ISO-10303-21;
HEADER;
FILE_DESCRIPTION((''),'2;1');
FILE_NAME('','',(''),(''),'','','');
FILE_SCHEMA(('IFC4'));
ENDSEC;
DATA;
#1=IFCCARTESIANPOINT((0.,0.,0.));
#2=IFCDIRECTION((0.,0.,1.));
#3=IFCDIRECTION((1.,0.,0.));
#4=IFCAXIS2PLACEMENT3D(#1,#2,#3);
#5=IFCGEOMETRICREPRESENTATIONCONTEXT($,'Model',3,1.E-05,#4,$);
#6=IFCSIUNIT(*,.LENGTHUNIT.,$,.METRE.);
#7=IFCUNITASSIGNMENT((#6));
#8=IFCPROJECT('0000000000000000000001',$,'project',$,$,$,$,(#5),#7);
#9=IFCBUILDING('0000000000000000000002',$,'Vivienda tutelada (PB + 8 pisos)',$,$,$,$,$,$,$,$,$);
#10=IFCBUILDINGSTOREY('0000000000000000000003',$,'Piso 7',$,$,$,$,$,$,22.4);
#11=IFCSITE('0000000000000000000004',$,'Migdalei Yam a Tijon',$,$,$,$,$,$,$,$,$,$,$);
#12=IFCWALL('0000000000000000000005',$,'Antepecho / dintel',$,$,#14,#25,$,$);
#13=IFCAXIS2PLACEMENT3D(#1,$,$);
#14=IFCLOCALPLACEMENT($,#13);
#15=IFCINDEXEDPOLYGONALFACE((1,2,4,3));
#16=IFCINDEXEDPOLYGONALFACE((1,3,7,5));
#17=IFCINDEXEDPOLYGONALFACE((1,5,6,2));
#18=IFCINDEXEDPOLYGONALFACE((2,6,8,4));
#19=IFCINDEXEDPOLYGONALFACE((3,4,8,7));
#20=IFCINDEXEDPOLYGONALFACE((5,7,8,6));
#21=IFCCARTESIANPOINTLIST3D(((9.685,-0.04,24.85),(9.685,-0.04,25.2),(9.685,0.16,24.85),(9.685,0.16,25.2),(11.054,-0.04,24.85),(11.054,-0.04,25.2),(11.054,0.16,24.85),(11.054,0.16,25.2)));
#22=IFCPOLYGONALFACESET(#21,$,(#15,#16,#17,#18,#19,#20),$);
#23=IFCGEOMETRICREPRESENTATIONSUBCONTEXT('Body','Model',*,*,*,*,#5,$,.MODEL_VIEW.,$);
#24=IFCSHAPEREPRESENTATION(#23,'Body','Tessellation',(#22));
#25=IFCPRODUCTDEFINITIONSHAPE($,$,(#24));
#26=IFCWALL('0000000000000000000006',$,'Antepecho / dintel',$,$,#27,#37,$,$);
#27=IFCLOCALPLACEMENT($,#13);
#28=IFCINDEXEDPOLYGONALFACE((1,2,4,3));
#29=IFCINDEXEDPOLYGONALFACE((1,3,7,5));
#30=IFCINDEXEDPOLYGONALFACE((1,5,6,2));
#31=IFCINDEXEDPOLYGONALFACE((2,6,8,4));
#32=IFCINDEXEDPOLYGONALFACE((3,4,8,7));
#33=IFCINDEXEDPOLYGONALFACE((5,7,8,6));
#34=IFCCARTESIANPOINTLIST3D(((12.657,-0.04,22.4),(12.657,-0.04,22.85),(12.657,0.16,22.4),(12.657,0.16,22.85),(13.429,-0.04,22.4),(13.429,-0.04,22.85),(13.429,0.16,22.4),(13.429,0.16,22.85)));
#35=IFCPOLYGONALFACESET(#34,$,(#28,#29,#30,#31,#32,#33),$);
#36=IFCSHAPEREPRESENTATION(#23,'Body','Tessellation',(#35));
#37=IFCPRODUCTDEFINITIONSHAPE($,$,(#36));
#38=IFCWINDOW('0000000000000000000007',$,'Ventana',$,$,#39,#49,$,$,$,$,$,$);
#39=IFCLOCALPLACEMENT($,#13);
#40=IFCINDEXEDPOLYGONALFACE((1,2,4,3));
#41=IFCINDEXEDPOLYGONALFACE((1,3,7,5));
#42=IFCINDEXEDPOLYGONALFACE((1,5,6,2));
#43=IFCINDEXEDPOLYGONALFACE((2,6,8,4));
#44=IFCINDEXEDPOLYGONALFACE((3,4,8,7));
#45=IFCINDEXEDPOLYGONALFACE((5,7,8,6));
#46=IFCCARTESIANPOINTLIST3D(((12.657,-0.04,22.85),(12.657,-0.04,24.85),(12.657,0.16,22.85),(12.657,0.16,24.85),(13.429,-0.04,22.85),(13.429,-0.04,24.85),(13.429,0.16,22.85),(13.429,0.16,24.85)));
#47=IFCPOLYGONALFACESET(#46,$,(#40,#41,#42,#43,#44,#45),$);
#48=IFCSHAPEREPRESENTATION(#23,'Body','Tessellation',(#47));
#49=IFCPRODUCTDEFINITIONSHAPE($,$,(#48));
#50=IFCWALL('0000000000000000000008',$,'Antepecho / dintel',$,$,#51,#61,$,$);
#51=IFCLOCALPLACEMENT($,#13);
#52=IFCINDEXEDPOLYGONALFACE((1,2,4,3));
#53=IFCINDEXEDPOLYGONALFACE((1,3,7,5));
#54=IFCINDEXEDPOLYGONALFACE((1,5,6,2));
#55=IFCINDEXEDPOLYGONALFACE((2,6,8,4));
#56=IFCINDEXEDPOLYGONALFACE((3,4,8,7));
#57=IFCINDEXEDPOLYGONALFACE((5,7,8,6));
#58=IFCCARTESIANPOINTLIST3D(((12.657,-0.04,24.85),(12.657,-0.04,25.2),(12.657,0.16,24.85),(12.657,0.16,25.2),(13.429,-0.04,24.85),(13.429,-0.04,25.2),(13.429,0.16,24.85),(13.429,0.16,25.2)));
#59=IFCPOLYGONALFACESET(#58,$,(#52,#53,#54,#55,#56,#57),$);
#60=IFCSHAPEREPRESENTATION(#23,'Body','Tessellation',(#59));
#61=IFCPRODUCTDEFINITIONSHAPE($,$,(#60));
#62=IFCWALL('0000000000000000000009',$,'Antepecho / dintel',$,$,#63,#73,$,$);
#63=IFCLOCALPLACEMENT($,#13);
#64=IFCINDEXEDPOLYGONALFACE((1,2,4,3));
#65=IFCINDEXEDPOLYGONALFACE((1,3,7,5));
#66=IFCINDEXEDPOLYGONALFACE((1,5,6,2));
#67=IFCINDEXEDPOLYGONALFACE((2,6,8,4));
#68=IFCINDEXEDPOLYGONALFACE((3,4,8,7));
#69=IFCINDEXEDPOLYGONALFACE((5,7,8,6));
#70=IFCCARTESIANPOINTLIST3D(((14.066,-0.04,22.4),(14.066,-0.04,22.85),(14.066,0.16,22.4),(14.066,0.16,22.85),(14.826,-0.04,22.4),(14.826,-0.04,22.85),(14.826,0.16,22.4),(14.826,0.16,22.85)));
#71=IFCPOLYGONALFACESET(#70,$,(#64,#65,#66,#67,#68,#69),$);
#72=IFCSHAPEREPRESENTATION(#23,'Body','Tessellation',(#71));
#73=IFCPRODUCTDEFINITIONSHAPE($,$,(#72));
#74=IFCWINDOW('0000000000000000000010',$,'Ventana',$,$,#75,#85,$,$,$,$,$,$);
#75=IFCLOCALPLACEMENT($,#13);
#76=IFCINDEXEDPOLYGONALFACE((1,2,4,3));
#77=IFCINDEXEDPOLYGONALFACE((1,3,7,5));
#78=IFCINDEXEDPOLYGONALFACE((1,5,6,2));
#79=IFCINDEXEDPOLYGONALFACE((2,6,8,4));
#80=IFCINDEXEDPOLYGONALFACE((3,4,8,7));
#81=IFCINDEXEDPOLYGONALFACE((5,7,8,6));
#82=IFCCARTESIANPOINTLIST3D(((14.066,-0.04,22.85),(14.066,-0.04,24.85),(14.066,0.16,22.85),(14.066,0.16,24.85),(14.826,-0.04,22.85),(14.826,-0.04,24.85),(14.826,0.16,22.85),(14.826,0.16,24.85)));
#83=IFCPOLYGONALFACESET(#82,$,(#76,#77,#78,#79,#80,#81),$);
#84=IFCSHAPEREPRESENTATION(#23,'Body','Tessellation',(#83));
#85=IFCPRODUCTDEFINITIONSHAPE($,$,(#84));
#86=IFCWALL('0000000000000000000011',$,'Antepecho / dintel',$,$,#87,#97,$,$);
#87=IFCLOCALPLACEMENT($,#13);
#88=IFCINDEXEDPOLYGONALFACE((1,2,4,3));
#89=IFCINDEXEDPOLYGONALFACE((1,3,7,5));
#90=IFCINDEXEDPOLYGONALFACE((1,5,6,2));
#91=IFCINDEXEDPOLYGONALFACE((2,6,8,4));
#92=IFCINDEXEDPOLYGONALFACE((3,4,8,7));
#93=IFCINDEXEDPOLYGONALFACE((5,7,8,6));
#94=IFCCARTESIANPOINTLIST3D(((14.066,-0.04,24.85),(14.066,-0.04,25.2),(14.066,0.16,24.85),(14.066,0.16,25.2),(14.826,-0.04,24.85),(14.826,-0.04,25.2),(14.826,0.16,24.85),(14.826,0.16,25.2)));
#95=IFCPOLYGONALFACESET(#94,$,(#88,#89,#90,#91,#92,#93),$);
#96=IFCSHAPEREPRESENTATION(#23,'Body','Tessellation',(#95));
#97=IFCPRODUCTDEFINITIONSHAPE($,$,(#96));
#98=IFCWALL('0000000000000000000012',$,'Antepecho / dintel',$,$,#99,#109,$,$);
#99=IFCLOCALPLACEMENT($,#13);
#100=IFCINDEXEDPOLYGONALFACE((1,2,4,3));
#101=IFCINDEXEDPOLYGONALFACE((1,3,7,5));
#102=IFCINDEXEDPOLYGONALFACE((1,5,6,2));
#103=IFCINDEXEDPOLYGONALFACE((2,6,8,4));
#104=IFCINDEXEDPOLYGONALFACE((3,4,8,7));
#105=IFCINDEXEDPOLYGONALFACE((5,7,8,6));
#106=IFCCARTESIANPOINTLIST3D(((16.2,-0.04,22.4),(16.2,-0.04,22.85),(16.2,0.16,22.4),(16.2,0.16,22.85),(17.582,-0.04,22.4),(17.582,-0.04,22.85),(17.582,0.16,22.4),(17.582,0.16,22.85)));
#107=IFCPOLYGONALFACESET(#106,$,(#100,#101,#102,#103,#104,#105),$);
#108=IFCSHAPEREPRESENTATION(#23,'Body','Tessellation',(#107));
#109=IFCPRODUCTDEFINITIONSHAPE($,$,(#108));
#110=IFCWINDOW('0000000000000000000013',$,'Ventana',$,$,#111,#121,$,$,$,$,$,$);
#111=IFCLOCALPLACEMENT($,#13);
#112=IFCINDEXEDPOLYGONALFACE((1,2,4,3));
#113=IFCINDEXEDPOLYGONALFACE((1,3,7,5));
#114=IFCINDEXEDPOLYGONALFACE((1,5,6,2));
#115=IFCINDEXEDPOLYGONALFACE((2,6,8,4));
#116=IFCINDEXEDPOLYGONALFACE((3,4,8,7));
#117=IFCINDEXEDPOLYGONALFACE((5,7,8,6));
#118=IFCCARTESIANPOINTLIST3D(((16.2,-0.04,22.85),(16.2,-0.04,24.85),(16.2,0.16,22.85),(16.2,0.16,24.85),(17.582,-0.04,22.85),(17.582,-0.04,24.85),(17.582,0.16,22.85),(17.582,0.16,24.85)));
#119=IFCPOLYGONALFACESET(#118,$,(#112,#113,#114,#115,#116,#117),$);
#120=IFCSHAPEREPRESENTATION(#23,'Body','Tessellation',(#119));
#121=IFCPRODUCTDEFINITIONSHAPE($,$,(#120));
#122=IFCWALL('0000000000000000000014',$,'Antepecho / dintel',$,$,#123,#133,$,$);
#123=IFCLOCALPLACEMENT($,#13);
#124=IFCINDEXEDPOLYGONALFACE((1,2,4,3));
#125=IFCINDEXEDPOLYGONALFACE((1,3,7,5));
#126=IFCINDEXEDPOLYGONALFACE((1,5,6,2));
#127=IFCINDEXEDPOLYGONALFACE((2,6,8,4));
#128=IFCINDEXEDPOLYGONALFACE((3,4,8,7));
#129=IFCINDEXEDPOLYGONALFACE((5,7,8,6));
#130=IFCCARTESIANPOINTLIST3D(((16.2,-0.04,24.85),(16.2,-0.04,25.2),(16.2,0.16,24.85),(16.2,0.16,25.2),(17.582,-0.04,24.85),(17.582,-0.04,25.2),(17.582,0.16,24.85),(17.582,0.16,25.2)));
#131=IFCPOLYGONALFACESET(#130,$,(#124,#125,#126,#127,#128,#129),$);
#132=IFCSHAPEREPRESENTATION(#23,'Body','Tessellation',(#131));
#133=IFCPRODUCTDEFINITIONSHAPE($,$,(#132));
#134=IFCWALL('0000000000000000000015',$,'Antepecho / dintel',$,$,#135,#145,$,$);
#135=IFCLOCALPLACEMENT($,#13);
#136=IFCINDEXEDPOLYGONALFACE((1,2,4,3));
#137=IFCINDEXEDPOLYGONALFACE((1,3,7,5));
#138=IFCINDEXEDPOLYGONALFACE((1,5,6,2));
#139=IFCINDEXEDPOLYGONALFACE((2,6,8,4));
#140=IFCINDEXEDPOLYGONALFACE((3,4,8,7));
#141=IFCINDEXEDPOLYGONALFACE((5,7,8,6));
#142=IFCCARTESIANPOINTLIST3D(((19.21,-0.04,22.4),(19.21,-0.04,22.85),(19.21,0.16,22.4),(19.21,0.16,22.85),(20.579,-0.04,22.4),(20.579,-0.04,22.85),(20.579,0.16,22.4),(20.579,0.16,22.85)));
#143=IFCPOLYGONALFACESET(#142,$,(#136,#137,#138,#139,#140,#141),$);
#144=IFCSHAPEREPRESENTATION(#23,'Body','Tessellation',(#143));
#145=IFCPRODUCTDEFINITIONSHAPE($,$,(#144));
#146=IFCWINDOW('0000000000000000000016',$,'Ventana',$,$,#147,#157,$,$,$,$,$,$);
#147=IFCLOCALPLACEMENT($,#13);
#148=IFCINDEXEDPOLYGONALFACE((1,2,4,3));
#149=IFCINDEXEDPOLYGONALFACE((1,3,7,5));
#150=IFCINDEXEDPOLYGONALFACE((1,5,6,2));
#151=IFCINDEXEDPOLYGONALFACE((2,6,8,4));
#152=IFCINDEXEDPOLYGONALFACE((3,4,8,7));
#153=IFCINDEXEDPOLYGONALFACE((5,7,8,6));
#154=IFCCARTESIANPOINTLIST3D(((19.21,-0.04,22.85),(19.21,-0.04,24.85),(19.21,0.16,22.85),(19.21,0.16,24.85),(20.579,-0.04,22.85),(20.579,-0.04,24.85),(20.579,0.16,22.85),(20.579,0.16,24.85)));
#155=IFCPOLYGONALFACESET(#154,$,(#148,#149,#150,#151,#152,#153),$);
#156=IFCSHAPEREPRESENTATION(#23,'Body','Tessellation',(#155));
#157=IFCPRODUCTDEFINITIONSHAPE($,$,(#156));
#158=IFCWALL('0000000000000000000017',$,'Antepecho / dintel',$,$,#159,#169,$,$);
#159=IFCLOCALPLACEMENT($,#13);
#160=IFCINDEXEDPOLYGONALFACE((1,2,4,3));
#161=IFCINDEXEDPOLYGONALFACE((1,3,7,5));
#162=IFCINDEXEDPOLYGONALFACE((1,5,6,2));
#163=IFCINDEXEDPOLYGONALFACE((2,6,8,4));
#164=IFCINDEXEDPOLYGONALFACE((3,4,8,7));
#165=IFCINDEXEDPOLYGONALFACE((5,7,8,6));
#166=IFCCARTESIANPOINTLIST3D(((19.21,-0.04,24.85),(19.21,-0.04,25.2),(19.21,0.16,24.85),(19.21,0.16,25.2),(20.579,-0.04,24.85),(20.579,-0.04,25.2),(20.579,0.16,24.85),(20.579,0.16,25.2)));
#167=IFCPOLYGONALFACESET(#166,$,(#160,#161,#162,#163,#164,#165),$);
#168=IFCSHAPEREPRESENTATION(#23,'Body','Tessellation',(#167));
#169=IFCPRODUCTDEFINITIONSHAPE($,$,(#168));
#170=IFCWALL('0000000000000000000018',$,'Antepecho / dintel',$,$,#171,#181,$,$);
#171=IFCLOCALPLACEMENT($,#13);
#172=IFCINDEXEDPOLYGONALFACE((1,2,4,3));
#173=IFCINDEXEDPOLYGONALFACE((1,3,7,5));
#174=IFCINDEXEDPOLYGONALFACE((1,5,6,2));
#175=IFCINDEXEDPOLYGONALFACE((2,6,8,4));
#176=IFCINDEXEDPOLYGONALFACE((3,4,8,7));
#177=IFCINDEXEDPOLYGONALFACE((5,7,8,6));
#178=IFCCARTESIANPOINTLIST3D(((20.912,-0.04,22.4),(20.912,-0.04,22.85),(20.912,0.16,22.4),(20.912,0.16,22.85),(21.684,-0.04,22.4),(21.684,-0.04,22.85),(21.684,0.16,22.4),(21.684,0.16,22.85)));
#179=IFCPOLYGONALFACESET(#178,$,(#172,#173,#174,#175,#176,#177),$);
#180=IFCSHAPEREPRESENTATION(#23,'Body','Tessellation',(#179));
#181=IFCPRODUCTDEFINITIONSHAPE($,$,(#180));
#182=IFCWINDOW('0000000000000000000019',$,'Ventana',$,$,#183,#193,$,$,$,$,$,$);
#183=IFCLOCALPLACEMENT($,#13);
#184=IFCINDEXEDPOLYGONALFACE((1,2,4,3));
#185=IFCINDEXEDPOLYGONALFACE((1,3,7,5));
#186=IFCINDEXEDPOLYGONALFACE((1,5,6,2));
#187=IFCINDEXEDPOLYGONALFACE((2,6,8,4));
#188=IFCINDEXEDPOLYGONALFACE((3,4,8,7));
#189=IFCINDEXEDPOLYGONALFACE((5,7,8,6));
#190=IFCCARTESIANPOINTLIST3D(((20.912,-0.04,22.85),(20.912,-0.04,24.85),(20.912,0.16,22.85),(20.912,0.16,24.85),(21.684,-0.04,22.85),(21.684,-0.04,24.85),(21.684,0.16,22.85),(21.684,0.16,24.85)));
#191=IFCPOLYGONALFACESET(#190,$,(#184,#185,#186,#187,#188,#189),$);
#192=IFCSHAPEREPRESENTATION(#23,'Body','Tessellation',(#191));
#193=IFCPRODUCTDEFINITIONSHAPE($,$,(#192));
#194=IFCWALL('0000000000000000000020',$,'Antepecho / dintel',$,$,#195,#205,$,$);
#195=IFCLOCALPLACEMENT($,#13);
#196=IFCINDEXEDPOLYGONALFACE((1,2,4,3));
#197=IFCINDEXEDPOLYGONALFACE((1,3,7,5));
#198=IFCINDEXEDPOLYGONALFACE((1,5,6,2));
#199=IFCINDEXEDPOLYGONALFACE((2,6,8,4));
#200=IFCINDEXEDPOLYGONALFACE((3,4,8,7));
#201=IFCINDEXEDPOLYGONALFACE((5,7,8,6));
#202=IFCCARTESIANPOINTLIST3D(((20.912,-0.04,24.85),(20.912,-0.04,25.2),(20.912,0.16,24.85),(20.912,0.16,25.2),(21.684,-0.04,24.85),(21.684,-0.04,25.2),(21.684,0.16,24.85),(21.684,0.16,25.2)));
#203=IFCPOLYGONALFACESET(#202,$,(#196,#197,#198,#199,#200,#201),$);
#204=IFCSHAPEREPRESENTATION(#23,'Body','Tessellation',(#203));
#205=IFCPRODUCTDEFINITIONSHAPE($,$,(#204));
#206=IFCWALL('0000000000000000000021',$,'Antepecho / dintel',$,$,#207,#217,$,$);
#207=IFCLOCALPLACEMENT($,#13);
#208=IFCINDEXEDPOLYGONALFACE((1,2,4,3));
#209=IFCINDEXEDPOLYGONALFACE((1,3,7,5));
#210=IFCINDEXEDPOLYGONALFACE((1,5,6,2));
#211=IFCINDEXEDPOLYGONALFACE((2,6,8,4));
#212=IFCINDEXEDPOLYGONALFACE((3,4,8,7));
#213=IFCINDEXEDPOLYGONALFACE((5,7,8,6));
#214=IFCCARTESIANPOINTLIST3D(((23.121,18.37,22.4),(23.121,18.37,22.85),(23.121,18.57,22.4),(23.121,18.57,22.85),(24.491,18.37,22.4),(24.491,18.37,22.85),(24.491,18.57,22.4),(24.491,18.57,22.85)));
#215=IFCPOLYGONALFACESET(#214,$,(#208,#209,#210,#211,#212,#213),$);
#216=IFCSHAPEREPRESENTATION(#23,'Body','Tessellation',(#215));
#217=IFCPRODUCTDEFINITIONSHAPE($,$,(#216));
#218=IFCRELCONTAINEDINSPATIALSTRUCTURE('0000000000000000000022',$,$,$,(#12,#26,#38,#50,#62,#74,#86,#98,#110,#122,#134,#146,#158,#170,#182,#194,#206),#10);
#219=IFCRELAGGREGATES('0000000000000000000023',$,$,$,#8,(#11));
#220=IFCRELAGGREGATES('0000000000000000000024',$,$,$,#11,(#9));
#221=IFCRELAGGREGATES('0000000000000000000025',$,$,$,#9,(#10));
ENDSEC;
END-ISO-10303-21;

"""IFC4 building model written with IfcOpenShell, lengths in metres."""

from ifc_helpers import new_model, si_unit, frame, origin_with_axes, context, subcontext, project, spatial, line, indexed_curve, outline, extrude, element, save


model = new_model("IFC4")

# Units and contexts
model_context = context("Model", 3, precision=1e-05, world=origin_with_axes())
body_context = subcontext(model_context, "Body", "Model", "MODEL_VIEW")
ifc_project = project(units=[si_unit("LENGTHUNIT", "METRE")], contexts=[model_context])

# Site, building, storey
site = spatial("IfcSite", under=ifc_project, Name="Migdalei Yam a Tijon")
building = spatial("IfcBuilding", under=site, Name="Vivienda tutelada (PB + 8 pisos)")
storey = spatial("IfcBuildingStorey", under=building, Name="Piso 7", Elevation=22.4)

# Walls
element("IfcWall", 1, inside=storey, Name="Antepecho / dintel", context=body_context, shape_type="SweptSolid", body=[
    extrude(outline(indexed_curve([(0.0, 0.0), (1.369, 0.0), (1.369, 0.2), (0.0, 0.2)], segments=[line(1, 2, 3, 4, 1)])), frame((9.685, -0.04, 24.85), z_axis=(0.0, 0.0, 1.0), x_axis=(1.0, 0.0, 0.0)), (0.0, 0.0, 1.0), 0.35),
])
element("IfcWall", 2, inside=storey, Name="Antepecho / dintel", context=body_context, shape_type="SweptSolid", body=[
    extrude(outline(indexed_curve([(0.0, 0.0), (0.772, 0.0), (0.772, 0.2), (0.0, 0.2)], segments=[line(1, 2, 3, 4, 1)])), frame((12.657, -0.04, 22.4), z_axis=(0.0, 0.0, 1.0), x_axis=(1.0, 0.0, 0.0)), (0.0, 0.0, 1.0), 0.45),
])

# Window
element("IfcWindow", 3, inside=storey, Name="Ventana", context=body_context, shape_type="SweptSolid", body=[
    extrude(outline(indexed_curve([(0.0, 0.0), (0.772, 0.0), (0.772, 0.2), (0.0, 0.2)], segments=[line(1, 2, 3, 4, 1)])), frame((12.657, -0.04, 22.85), z_axis=(0.0, 0.0, 1.0), x_axis=(1.0, 0.0, 0.0)), (0.0, 0.0, 1.0), 2.0),
])

# Walls
element("IfcWall", 4, inside=storey, Name="Antepecho / dintel", context=body_context, shape_type="SweptSolid", body=[
    extrude(outline(indexed_curve([(0.0, 0.0), (0.772, 0.0), (0.772, 0.2), (0.0, 0.2)], segments=[line(1, 2, 3, 4, 1)])), frame((12.657, -0.04, 24.85), z_axis=(0.0, 0.0, 1.0), x_axis=(1.0, 0.0, 0.0)), (0.0, 0.0, 1.0), 0.35),
])
element("IfcWall", 5, inside=storey, Name="Antepecho / dintel", context=body_context, shape_type="SweptSolid", body=[
    extrude(outline(indexed_curve([(0.0, 0.0), (0.76, 0.0), (0.76, 0.2), (0.0, 0.2)], segments=[line(1, 2, 3, 4, 1)])), frame((14.066, -0.04, 22.4), z_axis=(0.0, 0.0, 1.0), x_axis=(1.0, 0.0, 0.0)), (0.0, 0.0, 1.0), 0.45),
])

# Window
element("IfcWindow", 6, inside=storey, Name="Ventana", context=body_context, shape_type="SweptSolid", body=[
    extrude(outline(indexed_curve([(0.0, 0.0), (0.76, 0.0), (0.76, 0.2), (0.0, 0.2)], segments=[line(1, 2, 3, 4, 1)])), frame((14.066, -0.04, 22.85), z_axis=(0.0, 0.0, 1.0), x_axis=(1.0, 0.0, 0.0)), (0.0, 0.0, 1.0), 2.0),
])

# Walls
element("IfcWall", 7, inside=storey, Name="Antepecho / dintel", context=body_context, shape_type="SweptSolid", body=[
    extrude(outline(indexed_curve([(0.0, 0.0), (0.76, 0.0), (0.76, 0.2), (0.0, 0.2)], segments=[line(1, 2, 3, 4, 1)])), frame((14.066, -0.04, 24.85), z_axis=(0.0, 0.0, 1.0), x_axis=(1.0, 0.0, 0.0)), (0.0, 0.0, 1.0), 0.35),
])
element("IfcWall", 8, inside=storey, Name="Antepecho / dintel", context=body_context, shape_type="SweptSolid", body=[
    extrude(outline(indexed_curve([(0.0, 0.0), (1.382, 0.0), (1.382, 0.2), (0.0, 0.2)], segments=[line(1, 2, 3, 4, 1)])), frame((16.2, -0.04, 22.4), z_axis=(0.0, 0.0, 1.0), x_axis=(1.0, 0.0, 0.0)), (0.0, 0.0, 1.0), 0.45),
])

# Window
element("IfcWindow", 9, inside=storey, Name="Ventana", context=body_context, shape_type="SweptSolid", body=[
    extrude(outline(indexed_curve([(0.0, 0.0), (1.382, 0.0), (1.382, 0.2), (0.0, 0.2)], segments=[line(1, 2, 3, 4, 1)])), frame((16.2, -0.04, 22.85), z_axis=(0.0, 0.0, 1.0), x_axis=(1.0, 0.0, 0.0)), (0.0, 0.0, 1.0), 2.0),
])

# Walls
element("IfcWall", 10, inside=storey, Name="Antepecho / dintel", context=body_context, shape_type="SweptSolid", body=[
    extrude(outline(indexed_curve([(0.0, 0.0), (1.382, 0.0), (1.382, 0.2), (0.0, 0.2)], segments=[line(1, 2, 3, 4, 1)])), frame((16.2, -0.04, 24.85), z_axis=(0.0, 0.0, 1.0), x_axis=(1.0, 0.0, 0.0)), (0.0, 0.0, 1.0), 0.35),
])
element("IfcWall", 11, inside=storey, Name="Antepecho / dintel", context=body_context, shape_type="SweptSolid", body=[
    extrude(outline(indexed_curve([(0.0, 0.0), (1.369, 0.0), (1.369, 0.2), (0.0, 0.2)], segments=[line(1, 2, 3, 4, 1)])), frame((19.21, -0.04, 22.4), z_axis=(0.0, 0.0, 1.0), x_axis=(1.0, 0.0, 0.0)), (0.0, 0.0, 1.0), 0.45),
])

# Window
element("IfcWindow", 12, inside=storey, Name="Ventana", context=body_context, shape_type="SweptSolid", body=[
    extrude(outline(indexed_curve([(0.0, 0.0), (1.369, 0.0), (1.369, 0.2), (0.0, 0.2)], segments=[line(1, 2, 3, 4, 1)])), frame((19.21, -0.04, 22.85), z_axis=(0.0, 0.0, 1.0), x_axis=(1.0, 0.0, 0.0)), (0.0, 0.0, 1.0), 2.0),
])

# Walls
element("IfcWall", 13, inside=storey, Name="Antepecho / dintel", context=body_context, shape_type="SweptSolid", body=[
    extrude(outline(indexed_curve([(0.0, 0.0), (1.369, 0.0), (1.369, 0.2), (0.0, 0.2)], segments=[line(1, 2, 3, 4, 1)])), frame((19.21, -0.04, 24.85), z_axis=(0.0, 0.0, 1.0), x_axis=(1.0, 0.0, 0.0)), (0.0, 0.0, 1.0), 0.35),
])
element("IfcWall", 14, inside=storey, Name="Antepecho / dintel", context=body_context, shape_type="SweptSolid", body=[
    extrude(outline(indexed_curve([(0.0, 0.0), (0.772, 0.0), (0.772, 0.2), (0.0, 0.2)], segments=[line(1, 2, 3, 4, 1)])), frame((20.912, -0.04, 22.4), z_axis=(0.0, 0.0, 1.0), x_axis=(1.0, 0.0, 0.0)), (0.0, 0.0, 1.0), 0.45),
])

# Window
element("IfcWindow", 15, inside=storey, Name="Ventana", context=body_context, shape_type="SweptSolid", body=[
    extrude(outline(indexed_curve([(0.0, 0.0), (0.772, 0.0), (0.772, 0.2), (0.0, 0.2)], segments=[line(1, 2, 3, 4, 1)])), frame((20.912, -0.04, 22.85), z_axis=(0.0, 0.0, 1.0), x_axis=(1.0, 0.0, 0.0)), (0.0, 0.0, 1.0), 2.0),
])

# Walls
element("IfcWall", 16, inside=storey, Name="Antepecho / dintel", context=body_context, shape_type="SweptSolid", body=[
    extrude(outline(indexed_curve([(0.0, 0.0), (0.772, 0.0), (0.772, 0.2), (0.0, 0.2)], segments=[line(1, 2, 3, 4, 1)])), frame((20.912, -0.04, 24.85), z_axis=(0.0, 0.0, 1.0), x_axis=(1.0, 0.0, 0.0)), (0.0, 0.0, 1.0), 0.35),
])
element("IfcWall", 17, inside=storey, Name="Antepecho / dintel", context=body_context, shape_type="SweptSolid", body=[
    extrude(outline(indexed_curve([(0.0, 0.0), (1.37, 0.0), (1.37, 0.2), (0.0, 0.2)], segments=[line(1, 2, 3, 4, 1)])), frame((23.121, 18.37, 22.4), z_axis=(0.0, 0.0, 1.0), x_axis=(1.0, 0.0, 0.0)), (0.0, 0.0, 1.0), 0.45),
])

save(model, "model.ifc")
